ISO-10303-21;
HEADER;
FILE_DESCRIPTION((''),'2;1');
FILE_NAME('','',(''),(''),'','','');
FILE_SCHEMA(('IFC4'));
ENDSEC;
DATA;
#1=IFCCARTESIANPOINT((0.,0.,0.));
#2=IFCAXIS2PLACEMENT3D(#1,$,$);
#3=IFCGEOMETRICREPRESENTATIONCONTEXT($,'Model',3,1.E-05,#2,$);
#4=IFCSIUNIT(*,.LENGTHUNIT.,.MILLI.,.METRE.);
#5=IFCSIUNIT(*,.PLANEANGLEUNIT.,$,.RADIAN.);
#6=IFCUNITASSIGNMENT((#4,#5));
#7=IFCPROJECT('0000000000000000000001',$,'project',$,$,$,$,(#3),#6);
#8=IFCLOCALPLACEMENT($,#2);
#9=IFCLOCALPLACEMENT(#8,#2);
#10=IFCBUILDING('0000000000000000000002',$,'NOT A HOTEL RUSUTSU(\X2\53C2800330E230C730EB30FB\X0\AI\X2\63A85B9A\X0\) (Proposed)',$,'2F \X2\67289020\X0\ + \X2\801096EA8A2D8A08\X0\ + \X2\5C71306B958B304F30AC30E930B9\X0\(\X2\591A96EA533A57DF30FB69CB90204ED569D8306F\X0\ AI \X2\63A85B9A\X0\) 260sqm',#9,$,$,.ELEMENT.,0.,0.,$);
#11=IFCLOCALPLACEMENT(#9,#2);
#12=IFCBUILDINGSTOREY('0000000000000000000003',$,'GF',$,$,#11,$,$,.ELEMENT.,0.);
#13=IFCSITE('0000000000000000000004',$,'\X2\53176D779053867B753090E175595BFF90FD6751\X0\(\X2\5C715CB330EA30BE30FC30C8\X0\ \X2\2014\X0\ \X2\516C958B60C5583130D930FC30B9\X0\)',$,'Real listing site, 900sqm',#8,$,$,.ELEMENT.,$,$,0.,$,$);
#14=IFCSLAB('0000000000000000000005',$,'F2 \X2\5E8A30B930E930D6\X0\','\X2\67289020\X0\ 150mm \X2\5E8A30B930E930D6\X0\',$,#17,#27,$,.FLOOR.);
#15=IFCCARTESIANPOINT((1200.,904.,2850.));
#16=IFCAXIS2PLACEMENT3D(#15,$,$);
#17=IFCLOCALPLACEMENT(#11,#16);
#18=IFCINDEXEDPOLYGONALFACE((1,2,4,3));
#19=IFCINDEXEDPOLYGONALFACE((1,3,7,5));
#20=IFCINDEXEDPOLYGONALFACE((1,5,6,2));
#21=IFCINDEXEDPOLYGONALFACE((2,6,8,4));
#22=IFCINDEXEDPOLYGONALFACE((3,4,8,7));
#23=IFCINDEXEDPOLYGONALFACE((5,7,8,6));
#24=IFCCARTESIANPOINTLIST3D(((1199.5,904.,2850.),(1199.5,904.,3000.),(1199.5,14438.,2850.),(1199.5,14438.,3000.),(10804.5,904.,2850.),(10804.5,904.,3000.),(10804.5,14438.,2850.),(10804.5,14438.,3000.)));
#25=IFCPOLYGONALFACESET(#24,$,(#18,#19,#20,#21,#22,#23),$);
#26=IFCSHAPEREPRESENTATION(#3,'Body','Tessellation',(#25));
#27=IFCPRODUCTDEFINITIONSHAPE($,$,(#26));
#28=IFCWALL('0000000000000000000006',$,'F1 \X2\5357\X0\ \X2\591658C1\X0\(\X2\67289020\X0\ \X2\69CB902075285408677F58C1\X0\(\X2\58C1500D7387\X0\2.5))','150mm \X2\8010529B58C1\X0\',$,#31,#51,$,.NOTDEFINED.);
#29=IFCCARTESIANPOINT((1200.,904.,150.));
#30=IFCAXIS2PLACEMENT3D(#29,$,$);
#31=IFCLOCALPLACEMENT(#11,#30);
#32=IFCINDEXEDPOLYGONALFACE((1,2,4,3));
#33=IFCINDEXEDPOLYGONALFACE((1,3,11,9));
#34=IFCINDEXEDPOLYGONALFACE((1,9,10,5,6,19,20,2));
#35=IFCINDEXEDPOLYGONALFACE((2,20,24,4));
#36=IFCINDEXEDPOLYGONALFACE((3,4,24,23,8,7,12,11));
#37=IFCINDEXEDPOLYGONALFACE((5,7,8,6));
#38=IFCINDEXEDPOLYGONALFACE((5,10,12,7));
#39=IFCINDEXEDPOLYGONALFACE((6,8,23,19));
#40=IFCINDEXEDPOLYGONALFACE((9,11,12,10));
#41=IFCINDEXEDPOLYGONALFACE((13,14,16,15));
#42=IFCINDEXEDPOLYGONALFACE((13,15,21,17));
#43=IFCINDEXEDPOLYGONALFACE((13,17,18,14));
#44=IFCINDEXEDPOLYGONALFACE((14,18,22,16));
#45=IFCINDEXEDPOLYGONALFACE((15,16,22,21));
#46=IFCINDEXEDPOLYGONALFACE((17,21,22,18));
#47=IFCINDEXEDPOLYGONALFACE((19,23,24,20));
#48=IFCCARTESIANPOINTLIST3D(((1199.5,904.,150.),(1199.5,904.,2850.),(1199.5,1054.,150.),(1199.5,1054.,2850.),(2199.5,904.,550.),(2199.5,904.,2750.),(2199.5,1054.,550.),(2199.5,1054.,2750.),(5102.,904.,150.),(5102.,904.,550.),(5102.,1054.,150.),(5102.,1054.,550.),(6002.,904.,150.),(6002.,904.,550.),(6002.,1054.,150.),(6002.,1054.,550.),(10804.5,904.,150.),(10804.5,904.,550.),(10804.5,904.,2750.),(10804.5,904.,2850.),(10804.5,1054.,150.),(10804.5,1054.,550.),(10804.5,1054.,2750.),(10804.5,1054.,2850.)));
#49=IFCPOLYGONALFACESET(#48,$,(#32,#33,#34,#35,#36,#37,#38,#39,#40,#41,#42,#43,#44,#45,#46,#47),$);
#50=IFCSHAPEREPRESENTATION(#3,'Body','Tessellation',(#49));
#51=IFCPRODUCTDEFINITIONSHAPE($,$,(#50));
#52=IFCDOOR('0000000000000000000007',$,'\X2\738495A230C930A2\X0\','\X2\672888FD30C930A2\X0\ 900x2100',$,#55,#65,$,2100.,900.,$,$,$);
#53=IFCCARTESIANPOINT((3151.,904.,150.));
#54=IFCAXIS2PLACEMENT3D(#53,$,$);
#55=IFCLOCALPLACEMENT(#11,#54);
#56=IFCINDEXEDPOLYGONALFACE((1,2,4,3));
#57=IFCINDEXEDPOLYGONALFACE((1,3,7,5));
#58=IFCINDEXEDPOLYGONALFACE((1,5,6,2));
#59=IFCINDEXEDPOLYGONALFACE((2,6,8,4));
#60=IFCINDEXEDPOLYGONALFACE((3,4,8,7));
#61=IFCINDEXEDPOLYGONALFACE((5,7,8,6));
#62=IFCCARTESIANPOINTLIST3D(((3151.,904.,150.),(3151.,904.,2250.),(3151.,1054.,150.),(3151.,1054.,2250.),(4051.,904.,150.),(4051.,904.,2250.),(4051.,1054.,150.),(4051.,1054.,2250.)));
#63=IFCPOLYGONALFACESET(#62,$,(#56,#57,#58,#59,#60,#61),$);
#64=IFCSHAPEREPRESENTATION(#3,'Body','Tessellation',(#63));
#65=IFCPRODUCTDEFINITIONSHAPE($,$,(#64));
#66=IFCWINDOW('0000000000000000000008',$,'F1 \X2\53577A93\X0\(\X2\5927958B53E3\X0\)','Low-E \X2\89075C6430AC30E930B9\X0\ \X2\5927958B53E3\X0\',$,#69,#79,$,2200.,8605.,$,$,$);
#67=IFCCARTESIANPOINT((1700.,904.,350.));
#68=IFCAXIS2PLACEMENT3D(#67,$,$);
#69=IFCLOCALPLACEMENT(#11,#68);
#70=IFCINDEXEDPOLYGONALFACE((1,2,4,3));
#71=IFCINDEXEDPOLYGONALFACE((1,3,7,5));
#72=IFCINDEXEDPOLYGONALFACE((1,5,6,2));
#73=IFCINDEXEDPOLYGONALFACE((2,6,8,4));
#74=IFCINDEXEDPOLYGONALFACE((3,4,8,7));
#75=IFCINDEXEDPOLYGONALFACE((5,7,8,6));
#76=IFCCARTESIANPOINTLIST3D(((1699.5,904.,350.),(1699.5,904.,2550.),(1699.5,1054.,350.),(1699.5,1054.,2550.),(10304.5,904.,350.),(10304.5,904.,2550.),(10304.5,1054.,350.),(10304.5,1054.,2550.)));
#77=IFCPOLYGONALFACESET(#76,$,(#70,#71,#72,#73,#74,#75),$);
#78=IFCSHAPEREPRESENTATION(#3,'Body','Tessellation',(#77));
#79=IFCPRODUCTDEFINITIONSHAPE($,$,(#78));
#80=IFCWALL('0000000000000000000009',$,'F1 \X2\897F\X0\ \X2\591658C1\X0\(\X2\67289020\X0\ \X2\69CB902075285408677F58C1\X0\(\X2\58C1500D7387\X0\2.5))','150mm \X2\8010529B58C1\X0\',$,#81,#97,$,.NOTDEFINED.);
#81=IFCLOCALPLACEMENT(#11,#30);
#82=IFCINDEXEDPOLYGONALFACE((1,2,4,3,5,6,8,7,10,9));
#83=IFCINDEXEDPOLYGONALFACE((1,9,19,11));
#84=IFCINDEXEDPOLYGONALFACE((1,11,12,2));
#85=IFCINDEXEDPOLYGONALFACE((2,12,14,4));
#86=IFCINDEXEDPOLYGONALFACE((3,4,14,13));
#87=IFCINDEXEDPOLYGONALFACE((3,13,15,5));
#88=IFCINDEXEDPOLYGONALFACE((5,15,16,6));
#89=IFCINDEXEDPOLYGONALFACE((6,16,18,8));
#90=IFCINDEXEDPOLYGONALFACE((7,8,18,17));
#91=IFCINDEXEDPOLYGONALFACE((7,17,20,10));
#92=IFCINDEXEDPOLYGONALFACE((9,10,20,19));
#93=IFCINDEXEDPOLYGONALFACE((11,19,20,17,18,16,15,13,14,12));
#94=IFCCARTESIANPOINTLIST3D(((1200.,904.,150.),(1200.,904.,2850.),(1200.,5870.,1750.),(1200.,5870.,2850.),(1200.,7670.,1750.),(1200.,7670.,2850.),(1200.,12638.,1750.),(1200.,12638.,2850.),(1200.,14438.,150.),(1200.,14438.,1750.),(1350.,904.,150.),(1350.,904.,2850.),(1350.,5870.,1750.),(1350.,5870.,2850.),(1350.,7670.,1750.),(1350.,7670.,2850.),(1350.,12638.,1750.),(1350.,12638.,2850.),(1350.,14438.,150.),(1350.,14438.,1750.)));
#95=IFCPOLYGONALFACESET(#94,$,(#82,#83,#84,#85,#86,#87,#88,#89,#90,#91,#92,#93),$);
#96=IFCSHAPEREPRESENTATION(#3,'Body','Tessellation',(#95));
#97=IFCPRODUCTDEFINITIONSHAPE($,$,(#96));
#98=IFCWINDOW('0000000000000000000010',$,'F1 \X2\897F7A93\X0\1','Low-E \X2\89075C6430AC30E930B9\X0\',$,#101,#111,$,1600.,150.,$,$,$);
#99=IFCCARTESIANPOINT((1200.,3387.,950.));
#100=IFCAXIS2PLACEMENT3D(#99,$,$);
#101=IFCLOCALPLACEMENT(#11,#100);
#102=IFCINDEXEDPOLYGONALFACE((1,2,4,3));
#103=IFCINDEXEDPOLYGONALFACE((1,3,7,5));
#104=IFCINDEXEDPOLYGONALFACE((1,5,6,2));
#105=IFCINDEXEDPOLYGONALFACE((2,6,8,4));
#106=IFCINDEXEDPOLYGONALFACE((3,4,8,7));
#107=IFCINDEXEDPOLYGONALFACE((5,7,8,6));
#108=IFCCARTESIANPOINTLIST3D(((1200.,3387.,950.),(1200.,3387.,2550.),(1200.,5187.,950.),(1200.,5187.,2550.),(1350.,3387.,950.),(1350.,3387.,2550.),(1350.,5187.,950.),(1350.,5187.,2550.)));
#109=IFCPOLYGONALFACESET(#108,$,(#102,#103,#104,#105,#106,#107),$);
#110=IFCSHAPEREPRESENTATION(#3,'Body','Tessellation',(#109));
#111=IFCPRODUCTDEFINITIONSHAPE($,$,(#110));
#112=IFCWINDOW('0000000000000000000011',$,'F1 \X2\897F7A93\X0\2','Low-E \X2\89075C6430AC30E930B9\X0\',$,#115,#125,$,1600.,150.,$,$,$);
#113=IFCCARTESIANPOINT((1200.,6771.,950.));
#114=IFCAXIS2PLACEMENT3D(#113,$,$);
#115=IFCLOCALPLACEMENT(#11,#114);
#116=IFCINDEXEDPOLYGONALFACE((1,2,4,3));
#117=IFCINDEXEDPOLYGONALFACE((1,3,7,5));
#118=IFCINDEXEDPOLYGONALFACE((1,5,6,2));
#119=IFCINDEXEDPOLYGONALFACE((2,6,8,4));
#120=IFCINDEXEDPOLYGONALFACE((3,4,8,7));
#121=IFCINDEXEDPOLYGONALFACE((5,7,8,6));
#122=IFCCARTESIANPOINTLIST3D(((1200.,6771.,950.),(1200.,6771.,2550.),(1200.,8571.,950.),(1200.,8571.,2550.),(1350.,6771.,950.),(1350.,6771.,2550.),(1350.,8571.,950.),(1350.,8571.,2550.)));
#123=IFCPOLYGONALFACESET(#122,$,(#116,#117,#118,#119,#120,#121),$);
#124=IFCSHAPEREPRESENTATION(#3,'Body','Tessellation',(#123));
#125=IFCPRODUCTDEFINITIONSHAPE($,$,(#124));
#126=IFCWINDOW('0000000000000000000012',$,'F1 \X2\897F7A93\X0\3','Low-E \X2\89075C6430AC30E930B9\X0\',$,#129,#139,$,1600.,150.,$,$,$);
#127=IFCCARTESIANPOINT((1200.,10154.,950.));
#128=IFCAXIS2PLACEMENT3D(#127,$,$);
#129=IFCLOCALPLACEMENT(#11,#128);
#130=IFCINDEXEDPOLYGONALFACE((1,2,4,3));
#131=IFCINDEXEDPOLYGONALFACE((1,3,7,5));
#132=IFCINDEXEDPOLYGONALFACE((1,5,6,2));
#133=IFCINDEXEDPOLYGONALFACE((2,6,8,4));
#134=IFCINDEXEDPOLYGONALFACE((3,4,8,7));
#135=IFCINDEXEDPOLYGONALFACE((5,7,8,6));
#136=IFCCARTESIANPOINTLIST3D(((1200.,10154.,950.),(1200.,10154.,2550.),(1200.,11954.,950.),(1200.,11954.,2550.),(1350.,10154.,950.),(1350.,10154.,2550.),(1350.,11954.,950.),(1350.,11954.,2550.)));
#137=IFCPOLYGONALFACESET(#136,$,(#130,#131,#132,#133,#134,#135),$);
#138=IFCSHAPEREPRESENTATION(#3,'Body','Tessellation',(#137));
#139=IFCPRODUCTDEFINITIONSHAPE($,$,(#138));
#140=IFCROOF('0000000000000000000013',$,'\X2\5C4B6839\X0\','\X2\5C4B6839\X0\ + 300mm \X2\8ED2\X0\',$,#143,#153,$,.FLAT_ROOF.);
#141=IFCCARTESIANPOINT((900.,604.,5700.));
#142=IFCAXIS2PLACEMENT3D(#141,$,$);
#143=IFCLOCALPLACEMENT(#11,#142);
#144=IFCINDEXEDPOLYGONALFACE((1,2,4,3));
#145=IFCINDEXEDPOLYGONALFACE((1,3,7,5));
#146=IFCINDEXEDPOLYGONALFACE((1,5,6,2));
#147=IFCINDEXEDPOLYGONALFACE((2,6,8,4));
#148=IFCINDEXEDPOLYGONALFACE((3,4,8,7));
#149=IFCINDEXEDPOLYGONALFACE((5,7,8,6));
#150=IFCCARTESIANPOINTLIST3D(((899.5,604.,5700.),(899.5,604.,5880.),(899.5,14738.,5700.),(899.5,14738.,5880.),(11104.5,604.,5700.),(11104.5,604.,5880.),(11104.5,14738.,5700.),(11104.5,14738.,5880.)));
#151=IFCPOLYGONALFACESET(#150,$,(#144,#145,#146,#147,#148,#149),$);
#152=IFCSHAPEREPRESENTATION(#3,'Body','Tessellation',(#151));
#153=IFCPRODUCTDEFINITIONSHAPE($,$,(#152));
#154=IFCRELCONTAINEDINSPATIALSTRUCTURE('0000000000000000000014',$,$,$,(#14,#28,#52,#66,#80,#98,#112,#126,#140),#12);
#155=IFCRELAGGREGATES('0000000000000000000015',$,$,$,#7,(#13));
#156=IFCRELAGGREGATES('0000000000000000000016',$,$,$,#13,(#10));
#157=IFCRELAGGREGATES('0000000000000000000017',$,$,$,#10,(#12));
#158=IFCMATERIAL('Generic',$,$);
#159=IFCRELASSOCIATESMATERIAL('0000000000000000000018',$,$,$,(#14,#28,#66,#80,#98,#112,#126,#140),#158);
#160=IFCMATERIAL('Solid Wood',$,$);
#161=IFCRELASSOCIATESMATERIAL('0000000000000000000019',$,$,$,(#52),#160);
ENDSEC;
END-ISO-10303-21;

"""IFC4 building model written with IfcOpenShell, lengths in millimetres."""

from ifc_helpers import new_model, si_unit, frame, frame_2d, origin, place, context, project, spatial, rectangle, extrude, material, element, fill, save


model = new_model("IFC4")

# Units and contexts
model_context = context("Model", 3, precision=1e-05, world=origin())
ifc_project = project(units=[si_unit("LENGTHUNIT", "METRE", prefix="MILLI"), si_unit("PLANEANGLEUNIT", "RADIAN")], contexts=[model_context])

# Site, building, storey
site_placement = place(None, origin())
site = spatial("IfcSite", under=ifc_project, at=site_placement, Name="北海道虻田郡留寿都村(山岳リゾート — 公開情報ベース)", ObjectType="Real listing site, 900sqm", CompositionType="ELEMENT", RefElevation=0.0)
building_placement = place(site_placement, origin())
building = spatial("IfcBuilding", under=site, at=building_placement, Name="NOT A HOTEL RUSUTSU(参考モデル・AI推定) (Proposed)", ObjectType="2F 木造 + 耐雪設計 + 山に開くガラス(多雪区域・構造仕様は AI 推定) 260sqm", CompositionType="ELEMENT", ElevationOfRefHeight=0.0, ElevationOfTerrain=0.0)
storey_placement = place(building_placement, origin())
storey = spatial("IfcBuildingStorey", under=building, at=storey_placement, Name="GF", CompositionType="ELEMENT", Elevation=0.0)

# Slab
ifc_material_1 = material(Name="Generic")
slab_1_placement = place(storey_placement, frame((1200.0, 904.0, 2850.0)))
element("IfcSlab", 1, at=slab_1_placement, inside=storey, material=ifc_material_1, Name="F2 床スラブ", Description="木造 150mm 床スラブ", PredefinedType="FLOOR", context=model_context, shape_type="SweptSolid", body=[
    extrude(rectangle(XDim=9605.0, YDim=13534.0, at=frame_2d((4802.0, 6767.0))), frame((1200.0, 904.0, 2850.0)), (0.0, 0.0, 1.0), 150.0),
])

# Wall, openings, door, window
wall_1_placement = place(storey_placement, frame((1200.0, 904.0, 150.0)))
wall_1 = element("IfcWall", 2, at=wall_1_placement, inside=storey, material=ifc_material_1, Name="F1 南 外壁(木造 構造用合板壁(壁倍率2.5))", Description="150mm 耐力壁", PredefinedType="NOTDEFINED", context=model_context, shape_type="SweptSolid", body=[
    extrude(rectangle(XDim=9605.0, YDim=150.0, at=frame_2d((4802.0, 75.0))), frame((1200.0, 904.0, 150.0)), (0.0, 0.0, 1.0), 2700.0),
])
opening_1_placement = place(storey_placement, frame((3151.0, 904.0, 150.0)))
opening_1 = element("IfcOpeningElement", 3, at=opening_1_placement, cuts=wall_1, PredefinedType="NOTDEFINED", context=model_context, shape_type="SweptSolid", body=[
    extrude(rectangle(XDim=900.0, YDim=150.0, at=frame_2d((450.0, 75.0))), frame((3151.0, 904.0, 150.0)), (0.0, 0.0, 1.0), 2100.0),
])
opening_2_placement = place(storey_placement, frame((1700.0, 904.0, 350.0)))
opening_2 = element("IfcOpeningElement", 4, at=opening_2_placement, cuts=wall_1, PredefinedType="NOTDEFINED", context=model_context, shape_type="SweptSolid", body=[
    extrude(rectangle(XDim=8605.0, YDim=150.0, at=frame_2d((4302.0, 75.0))), frame((1700.0, 904.0, 350.0)), (0.0, 0.0, 1.0), 2200.0),
])
ifc_material_2 = material(Name="Solid Wood")
door_placement = place(storey_placement, frame((3151.0, 904.0, 150.0)))
door = element("IfcDoor", 5, at=door_placement, inside=storey, material=ifc_material_2, Name="玄関ドア", Description="木製ドア 900x2100", OverallHeight=2100.0, OverallWidth=900.0, context=model_context, shape_type="SweptSolid", body=[
    extrude(rectangle(XDim=900.0, YDim=150.0, at=frame_2d((450.0, 75.0))), frame((3151.0, 904.0, 150.0)), (0.0, 0.0, 1.0), 2100.0),
])
fill(opening_1, door)
window_1_placement = place(storey_placement, frame((1700.0, 904.0, 350.0)))
window_1 = element("IfcWindow", 6, at=window_1_placement, inside=storey, material=ifc_material_1, Name="F1 南窓(大開口)", Description="Low-E 複層ガラス 大開口", OverallHeight=2200.0, OverallWidth=8605.0, context=model_context, shape_type="SweptSolid", body=[
    extrude(rectangle(XDim=8605.0, YDim=150.0, at=frame_2d((4302.0, 75.0))), frame((1700.0, 904.0, 350.0)), (0.0, 0.0, 1.0), 2200.0),
])
fill(opening_2, window_1)

# Wall, openings, windows
wall_2_placement = place(storey_placement, frame((1200.0, 904.0, 150.0)))
wall_2 = element("IfcWall", 7, at=wall_2_placement, inside=storey, material=ifc_material_1, Name="F1 西 外壁(木造 構造用合板壁(壁倍率2.5))", Description="150mm 耐力壁", PredefinedType="NOTDEFINED", context=model_context, shape_type="SweptSolid", body=[
    extrude(rectangle(XDim=150.0, YDim=13534.0, at=frame_2d((75.0, 6767.0))), frame((1200.0, 904.0, 150.0)), (0.0, 0.0, 1.0), 2700.0),
])
opening_3_placement = place(storey_placement, frame((1200.0, 3387.0, 950.0)))
opening_3 = element("IfcOpeningElement", 8, at=opening_3_placement, cuts=wall_2, PredefinedType="NOTDEFINED", context=model_context, shape_type="SweptSolid", body=[
    extrude(rectangle(XDim=150.0, YDim=1800.0, at=frame_2d((75.0, 900.0))), frame((1200.0, 3387.0, 950.0)), (0.0, 0.0, 1.0), 1600.0),
])
opening_4_placement = place(storey_placement, frame((1200.0, 6771.0, 950.0)))
opening_4 = element("IfcOpeningElement", 9, at=opening_4_placement, cuts=wall_2, PredefinedType="NOTDEFINED", context=model_context, shape_type="SweptSolid", body=[
    extrude(rectangle(XDim=150.0, YDim=1800.0, at=frame_2d((75.0, 900.0))), frame((1200.0, 6771.0, 950.0)), (0.0, 0.0, 1.0), 1600.0),
])
opening_5_placement = place(storey_placement, frame((1200.0, 10154.0, 950.0)))
opening_5 = element("IfcOpeningElement", 10, at=opening_5_placement, cuts=wall_2, PredefinedType="NOTDEFINED", context=model_context, shape_type="SweptSolid", body=[
    extrude(rectangle(XDim=150.0, YDim=1800.0, at=frame_2d((75.0, 900.0))), frame((1200.0, 10154.0, 950.0)), (0.0, 0.0, 1.0), 1600.0),
])
window_2_placement = place(storey_placement, frame((1200.0, 3387.0, 950.0)))
window_2 = element("IfcWindow", 11, at=window_2_placement, inside=storey, material=ifc_material_1, Name="F1 西窓1", Description="Low-E 複層ガラス", OverallHeight=1600.0, OverallWidth=150.0, context=model_context, shape_type="SweptSolid", body=[
    extrude(rectangle(XDim=150.0, YDim=1800.0, at=frame_2d((75.0, 900.0))), frame((1200.0, 3387.0, 950.0)), (0.0, 0.0, 1.0), 1600.0),
])
fill(opening_3, window_2)
window_3_placement = place(storey_placement, frame((1200.0, 6771.0, 950.0)))
window_3 = element("IfcWindow", 12, at=window_3_placement, inside=storey, material=ifc_material_1, Name="F1 西窓2", Description="Low-E 複層ガラス", OverallHeight=1600.0, OverallWidth=150.0, context=model_context, shape_type="SweptSolid", body=[
    extrude(rectangle(XDim=150.0, YDim=1800.0, at=frame_2d((75.0, 900.0))), frame((1200.0, 6771.0, 950.0)), (0.0, 0.0, 1.0), 1600.0),
])
fill(opening_4, window_3)
window_4_placement = place(storey_placement, frame((1200.0, 10154.0, 950.0)))
window_4 = element("IfcWindow", 13, at=window_4_placement, inside=storey, material=ifc_material_1, Name="F1 西窓3", Description="Low-E 複層ガラス", OverallHeight=1600.0, OverallWidth=150.0, context=model_context, shape_type="SweptSolid", body=[
    extrude(rectangle(XDim=150.0, YDim=1800.0, at=frame_2d((75.0, 900.0))), frame((1200.0, 10154.0, 950.0)), (0.0, 0.0, 1.0), 1600.0),
])
fill(opening_5, window_4)

# Roof
roof_placement = place(storey_placement, frame((900.0, 604.0, 5700.0)))
element("IfcRoof", 14, at=roof_placement, inside=storey, material=ifc_material_1, Name="屋根", Description="屋根 + 300mm 軒", PredefinedType="FLAT_ROOF", context=model_context, shape_type="SweptSolid", body=[
    extrude(rectangle(XDim=10205.0, YDim=14134.0, at=frame_2d((5102.0, 7067.0))), frame((900.0, 604.0, 5700.0)), (0.0, 0.0, 1.0), 180.0),
])

save(model, "model.ifc")
